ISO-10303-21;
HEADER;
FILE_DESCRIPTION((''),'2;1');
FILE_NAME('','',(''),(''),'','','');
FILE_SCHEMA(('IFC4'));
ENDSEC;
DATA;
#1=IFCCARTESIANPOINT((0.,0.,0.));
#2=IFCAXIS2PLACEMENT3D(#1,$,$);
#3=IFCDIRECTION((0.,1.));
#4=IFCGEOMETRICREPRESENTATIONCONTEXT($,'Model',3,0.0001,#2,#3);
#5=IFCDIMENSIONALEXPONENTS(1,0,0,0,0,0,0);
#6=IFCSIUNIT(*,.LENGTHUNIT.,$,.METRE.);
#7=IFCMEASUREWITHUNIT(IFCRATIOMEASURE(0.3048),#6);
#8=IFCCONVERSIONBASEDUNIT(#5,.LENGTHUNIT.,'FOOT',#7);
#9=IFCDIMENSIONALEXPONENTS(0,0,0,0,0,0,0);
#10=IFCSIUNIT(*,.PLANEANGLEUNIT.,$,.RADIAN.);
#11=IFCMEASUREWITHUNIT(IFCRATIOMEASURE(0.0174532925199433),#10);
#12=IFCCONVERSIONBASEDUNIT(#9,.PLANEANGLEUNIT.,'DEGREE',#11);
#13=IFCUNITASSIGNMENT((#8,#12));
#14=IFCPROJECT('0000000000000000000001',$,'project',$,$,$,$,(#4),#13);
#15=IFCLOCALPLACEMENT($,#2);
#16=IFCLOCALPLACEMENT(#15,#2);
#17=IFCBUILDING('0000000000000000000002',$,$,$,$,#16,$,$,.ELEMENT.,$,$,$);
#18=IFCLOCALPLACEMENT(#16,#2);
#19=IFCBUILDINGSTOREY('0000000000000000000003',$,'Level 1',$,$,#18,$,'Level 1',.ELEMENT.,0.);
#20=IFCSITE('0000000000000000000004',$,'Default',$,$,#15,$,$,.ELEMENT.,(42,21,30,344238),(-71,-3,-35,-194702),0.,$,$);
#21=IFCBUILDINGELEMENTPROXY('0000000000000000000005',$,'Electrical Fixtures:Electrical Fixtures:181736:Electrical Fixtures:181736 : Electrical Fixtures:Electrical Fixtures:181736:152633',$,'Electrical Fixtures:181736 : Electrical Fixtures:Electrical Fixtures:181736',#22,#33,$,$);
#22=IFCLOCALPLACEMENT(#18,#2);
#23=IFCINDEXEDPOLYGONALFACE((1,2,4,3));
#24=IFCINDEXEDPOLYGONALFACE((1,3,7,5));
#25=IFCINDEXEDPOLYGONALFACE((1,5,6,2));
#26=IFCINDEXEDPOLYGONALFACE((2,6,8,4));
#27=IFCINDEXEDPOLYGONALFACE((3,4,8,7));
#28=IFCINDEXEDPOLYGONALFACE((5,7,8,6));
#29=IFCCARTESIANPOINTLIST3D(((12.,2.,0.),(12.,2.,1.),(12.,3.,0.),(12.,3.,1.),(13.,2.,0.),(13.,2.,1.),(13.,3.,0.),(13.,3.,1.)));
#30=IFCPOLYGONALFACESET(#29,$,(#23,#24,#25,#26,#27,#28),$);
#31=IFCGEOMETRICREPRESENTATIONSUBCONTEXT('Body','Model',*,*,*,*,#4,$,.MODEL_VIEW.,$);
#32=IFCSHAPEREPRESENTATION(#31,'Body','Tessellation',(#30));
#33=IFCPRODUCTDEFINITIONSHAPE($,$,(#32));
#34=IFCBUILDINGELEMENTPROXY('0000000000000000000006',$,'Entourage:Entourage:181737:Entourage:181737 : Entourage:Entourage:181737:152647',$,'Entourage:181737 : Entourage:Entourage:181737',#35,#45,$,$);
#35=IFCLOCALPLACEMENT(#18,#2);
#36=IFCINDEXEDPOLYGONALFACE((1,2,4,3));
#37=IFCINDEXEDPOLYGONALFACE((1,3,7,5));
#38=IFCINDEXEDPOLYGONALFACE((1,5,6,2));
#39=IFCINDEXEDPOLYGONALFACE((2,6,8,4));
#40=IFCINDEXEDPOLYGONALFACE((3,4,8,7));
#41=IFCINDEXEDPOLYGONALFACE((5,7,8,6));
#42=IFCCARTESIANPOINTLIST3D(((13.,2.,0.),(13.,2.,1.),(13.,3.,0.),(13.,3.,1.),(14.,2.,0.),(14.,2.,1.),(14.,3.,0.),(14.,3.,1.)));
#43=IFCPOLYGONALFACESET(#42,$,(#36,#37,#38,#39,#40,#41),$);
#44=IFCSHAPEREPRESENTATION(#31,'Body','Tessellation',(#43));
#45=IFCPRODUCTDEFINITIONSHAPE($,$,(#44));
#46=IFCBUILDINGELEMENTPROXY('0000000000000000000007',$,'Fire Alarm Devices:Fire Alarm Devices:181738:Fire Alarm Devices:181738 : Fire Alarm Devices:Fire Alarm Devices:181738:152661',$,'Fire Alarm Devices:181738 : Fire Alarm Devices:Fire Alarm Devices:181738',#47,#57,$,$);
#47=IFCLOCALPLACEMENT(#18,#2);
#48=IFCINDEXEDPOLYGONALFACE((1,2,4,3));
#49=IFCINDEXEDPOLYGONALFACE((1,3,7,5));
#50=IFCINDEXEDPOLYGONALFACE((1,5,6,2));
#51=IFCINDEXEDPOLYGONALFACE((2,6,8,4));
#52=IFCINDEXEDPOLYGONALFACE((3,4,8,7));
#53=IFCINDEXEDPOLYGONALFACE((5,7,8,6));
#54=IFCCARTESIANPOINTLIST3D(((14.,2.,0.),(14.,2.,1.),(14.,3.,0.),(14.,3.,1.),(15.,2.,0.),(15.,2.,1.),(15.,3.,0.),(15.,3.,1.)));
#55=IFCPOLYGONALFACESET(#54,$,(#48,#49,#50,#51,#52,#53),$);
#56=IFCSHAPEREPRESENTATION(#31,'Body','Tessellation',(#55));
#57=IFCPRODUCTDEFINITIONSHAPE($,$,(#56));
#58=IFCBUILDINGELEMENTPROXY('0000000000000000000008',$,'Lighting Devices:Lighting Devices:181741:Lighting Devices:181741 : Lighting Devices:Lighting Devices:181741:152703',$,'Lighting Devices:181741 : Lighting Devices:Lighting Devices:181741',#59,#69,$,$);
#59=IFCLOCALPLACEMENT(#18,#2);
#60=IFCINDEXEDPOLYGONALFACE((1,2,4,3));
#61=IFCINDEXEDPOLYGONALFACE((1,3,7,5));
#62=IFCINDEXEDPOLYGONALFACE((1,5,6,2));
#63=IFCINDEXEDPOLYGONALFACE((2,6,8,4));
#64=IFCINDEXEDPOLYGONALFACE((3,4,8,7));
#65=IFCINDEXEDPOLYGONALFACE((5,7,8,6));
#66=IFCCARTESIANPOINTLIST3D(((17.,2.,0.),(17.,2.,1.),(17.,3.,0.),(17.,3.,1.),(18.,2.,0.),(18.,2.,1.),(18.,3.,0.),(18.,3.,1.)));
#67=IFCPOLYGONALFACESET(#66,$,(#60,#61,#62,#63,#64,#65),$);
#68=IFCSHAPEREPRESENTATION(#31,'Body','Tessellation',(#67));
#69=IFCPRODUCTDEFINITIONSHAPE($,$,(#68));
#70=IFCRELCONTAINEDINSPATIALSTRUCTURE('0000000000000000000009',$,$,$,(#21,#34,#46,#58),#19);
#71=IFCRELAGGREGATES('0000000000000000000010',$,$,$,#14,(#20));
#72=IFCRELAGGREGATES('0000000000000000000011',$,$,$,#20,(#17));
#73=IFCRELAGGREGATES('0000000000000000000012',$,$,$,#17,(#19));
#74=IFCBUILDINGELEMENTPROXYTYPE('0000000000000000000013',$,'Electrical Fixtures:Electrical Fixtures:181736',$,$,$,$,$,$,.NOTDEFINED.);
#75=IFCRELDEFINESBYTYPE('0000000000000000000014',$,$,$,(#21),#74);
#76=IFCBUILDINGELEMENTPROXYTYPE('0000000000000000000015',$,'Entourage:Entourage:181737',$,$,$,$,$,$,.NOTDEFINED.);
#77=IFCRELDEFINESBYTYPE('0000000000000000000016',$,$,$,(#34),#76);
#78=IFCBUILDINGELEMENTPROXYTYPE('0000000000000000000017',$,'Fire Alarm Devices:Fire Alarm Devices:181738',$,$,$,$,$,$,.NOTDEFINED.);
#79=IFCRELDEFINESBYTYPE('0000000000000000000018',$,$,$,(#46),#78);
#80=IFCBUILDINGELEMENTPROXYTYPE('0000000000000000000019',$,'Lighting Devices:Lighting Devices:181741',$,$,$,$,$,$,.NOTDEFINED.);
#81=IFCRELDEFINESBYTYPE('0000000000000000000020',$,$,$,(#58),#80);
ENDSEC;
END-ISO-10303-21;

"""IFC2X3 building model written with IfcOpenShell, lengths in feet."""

from ifc_helpers import new_model, entity, si_unit, converted_unit, direction, frame, frame_2d, origin, place, context, subcontext, project, spatial, rectangle, extrude, source, transform, mapped, type_object, type_shapes, element, save


model = new_model("IFC2X3")

# Units and contexts
model_context = context("Model", 3, precision=0.0001, world=origin(), true_north=direction((0.0, 1.0)))
body_context = subcontext(model_context, "Body", "Model", "MODEL_VIEW")
ifc_project = project(units=[converted_unit("LENGTHUNIT", "FOOT", entity("IfcRatioMeasure", 0.3048), si_unit("LENGTHUNIT", "METRE"), dimensions=[1, 0, 0, 0, 0, 0, 0]), converted_unit("PLANEANGLEUNIT", "DEGREE", entity("IfcRatioMeasure", 0.0174532925199433), si_unit("PLANEANGLEUNIT", "RADIAN"), dimensions=[0, 0, 0, 0, 0, 0, 0])], contexts=[model_context])

# Site, building, storey
site_placement = place(None, origin())
site = spatial("IfcSite", under=ifc_project, at=site_placement, Name="Default", CompositionType="ELEMENT", RefLatitude=(42, 21, 30, 344238), RefLongitude=(-71, -3, -35, -194702), RefElevation=0.0)
building_placement = place(site_placement, origin())
building = spatial("IfcBuilding", under=site, at=building_placement, CompositionType="ELEMENT")
storey_placement = place(building_placement, origin())
storey = spatial("IfcBuildingStorey", under=building, at=storey_placement, Name="Level 1", LongName="Level 1", CompositionType="ELEMENT", Elevation=0.0)

# Building element proxies
building_element_proxy_type_1 = type_object("IfcBuildingElementProxyType", Name="Electrical Fixtures:Electrical Fixtures:181736", PredefinedType="NOTDEFINED")
shared_shape_1 = source(origin(), body_context, "Body", "SweptSolid", [
    extrude(rectangle(XDim=1.0, YDim=1.0, at=frame_2d((0.0, 0.0), x_axis=(1.0, 0.0))), frame((12.5, 2.5, 0.0), z_axis=(0.0, 0.0, 1.0), x_axis=(-1.0, 0.0, 0.0)), (0.0, 0.0, 1.0), 1.0),
])
type_shapes(building_element_proxy_type_1, [shared_shape_1])
proxy_1_placement = place(storey_placement, origin())
element("IfcBuildingElementProxy", 1, at=proxy_1_placement, inside=storey, type_object=building_element_proxy_type_1, Name="Electrical Fixtures:Electrical Fixtures:181736:Electrical Fixtures:181736 : Electrical Fixtures:Electrical Fixtures:181736:152633", ObjectType="Electrical Fixtures:181736 : Electrical Fixtures:Electrical Fixtures:181736", context=body_context, shape_type="MappedRepresentation", body=[
    mapped(shared_shape_1, transform((0.0, 0.0, 0.0), scale=1.0)),
])
building_element_proxy_type_2 = type_object("IfcBuildingElementProxyType", Name="Entourage:Entourage:181737", PredefinedType="NOTDEFINED")
shared_shape_2 = source(origin(), body_context, "Body", "SweptSolid", [
    extrude(rectangle(XDim=1.0, YDim=1.0, at=frame_2d((0.0, 0.0), x_axis=(1.0, 0.0))), frame((13.5, 2.5, 0.0), z_axis=(0.0, 0.0, 1.0), x_axis=(-1.0, 0.0, 0.0)), (0.0, 0.0, 1.0), 1.0),
])
type_shapes(building_element_proxy_type_2, [shared_shape_2])
proxy_2_placement = place(storey_placement, origin())
element("IfcBuildingElementProxy", 2, at=proxy_2_placement, inside=storey, type_object=building_element_proxy_type_2, Name="Entourage:Entourage:181737:Entourage:181737 : Entourage:Entourage:181737:152647", ObjectType="Entourage:181737 : Entourage:Entourage:181737", context=body_context, shape_type="MappedRepresentation", body=[
    mapped(shared_shape_2, transform((0.0, 0.0, 0.0), scale=1.0)),
])
building_element_proxy_type_3 = type_object("IfcBuildingElementProxyType", Name="Fire Alarm Devices:Fire Alarm Devices:181738", PredefinedType="NOTDEFINED")
shared_shape_3 = source(origin(), body_context, "Body", "SweptSolid", [
    extrude(rectangle(XDim=1.0, YDim=1.0, at=frame_2d((0.0, 0.0), x_axis=(1.0, 0.0))), frame((14.5, 2.5, 0.0), z_axis=(0.0, 0.0, 1.0), x_axis=(-1.0, 0.0, 0.0)), (0.0, 0.0, 1.0), 1.0),
])
type_shapes(building_element_proxy_type_3, [shared_shape_3])
proxy_3_placement = place(storey_placement, origin())
element("IfcBuildingElementProxy", 3, at=proxy_3_placement, inside=storey, type_object=building_element_proxy_type_3, Name="Fire Alarm Devices:Fire Alarm Devices:181738:Fire Alarm Devices:181738 : Fire Alarm Devices:Fire Alarm Devices:181738:152661", ObjectType="Fire Alarm Devices:181738 : Fire Alarm Devices:Fire Alarm Devices:181738", context=body_context, shape_type="MappedRepresentation", body=[
    mapped(shared_shape_3, transform((0.0, 0.0, 0.0), scale=1.0)),
])
building_element_proxy_type_4 = type_object("IfcBuildingElementProxyType", Name="Lighting Devices:Lighting Devices:181741", PredefinedType="NOTDEFINED")
shared_shape_4 = source(origin(), body_context, "Body", "SweptSolid", [
    extrude(rectangle(XDim=1.0, YDim=1.0, at=frame_2d((0.0, 0.0), x_axis=(1.0, 0.0))), frame((17.5, 2.5, 0.0), z_axis=(0.0, 0.0, 1.0), x_axis=(-1.0, 0.0, 0.0)), (0.0, 0.0, 1.0), 1.0),
])
type_shapes(building_element_proxy_type_4, [shared_shape_4])
proxy_4_placement = place(storey_placement, origin())
element("IfcBuildingElementProxy", 4, at=proxy_4_placement, inside=storey, type_object=building_element_proxy_type_4, Name="Lighting Devices:Lighting Devices:181741:Lighting Devices:181741 : Lighting Devices:Lighting Devices:181741:152703", ObjectType="Lighting Devices:181741 : Lighting Devices:Lighting Devices:181741", context=body_context, shape_type="MappedRepresentation", body=[
    mapped(shared_shape_4, transform((0.0, 0.0, 0.0), scale=1.0)),
])

save(model, "model.ifc")
